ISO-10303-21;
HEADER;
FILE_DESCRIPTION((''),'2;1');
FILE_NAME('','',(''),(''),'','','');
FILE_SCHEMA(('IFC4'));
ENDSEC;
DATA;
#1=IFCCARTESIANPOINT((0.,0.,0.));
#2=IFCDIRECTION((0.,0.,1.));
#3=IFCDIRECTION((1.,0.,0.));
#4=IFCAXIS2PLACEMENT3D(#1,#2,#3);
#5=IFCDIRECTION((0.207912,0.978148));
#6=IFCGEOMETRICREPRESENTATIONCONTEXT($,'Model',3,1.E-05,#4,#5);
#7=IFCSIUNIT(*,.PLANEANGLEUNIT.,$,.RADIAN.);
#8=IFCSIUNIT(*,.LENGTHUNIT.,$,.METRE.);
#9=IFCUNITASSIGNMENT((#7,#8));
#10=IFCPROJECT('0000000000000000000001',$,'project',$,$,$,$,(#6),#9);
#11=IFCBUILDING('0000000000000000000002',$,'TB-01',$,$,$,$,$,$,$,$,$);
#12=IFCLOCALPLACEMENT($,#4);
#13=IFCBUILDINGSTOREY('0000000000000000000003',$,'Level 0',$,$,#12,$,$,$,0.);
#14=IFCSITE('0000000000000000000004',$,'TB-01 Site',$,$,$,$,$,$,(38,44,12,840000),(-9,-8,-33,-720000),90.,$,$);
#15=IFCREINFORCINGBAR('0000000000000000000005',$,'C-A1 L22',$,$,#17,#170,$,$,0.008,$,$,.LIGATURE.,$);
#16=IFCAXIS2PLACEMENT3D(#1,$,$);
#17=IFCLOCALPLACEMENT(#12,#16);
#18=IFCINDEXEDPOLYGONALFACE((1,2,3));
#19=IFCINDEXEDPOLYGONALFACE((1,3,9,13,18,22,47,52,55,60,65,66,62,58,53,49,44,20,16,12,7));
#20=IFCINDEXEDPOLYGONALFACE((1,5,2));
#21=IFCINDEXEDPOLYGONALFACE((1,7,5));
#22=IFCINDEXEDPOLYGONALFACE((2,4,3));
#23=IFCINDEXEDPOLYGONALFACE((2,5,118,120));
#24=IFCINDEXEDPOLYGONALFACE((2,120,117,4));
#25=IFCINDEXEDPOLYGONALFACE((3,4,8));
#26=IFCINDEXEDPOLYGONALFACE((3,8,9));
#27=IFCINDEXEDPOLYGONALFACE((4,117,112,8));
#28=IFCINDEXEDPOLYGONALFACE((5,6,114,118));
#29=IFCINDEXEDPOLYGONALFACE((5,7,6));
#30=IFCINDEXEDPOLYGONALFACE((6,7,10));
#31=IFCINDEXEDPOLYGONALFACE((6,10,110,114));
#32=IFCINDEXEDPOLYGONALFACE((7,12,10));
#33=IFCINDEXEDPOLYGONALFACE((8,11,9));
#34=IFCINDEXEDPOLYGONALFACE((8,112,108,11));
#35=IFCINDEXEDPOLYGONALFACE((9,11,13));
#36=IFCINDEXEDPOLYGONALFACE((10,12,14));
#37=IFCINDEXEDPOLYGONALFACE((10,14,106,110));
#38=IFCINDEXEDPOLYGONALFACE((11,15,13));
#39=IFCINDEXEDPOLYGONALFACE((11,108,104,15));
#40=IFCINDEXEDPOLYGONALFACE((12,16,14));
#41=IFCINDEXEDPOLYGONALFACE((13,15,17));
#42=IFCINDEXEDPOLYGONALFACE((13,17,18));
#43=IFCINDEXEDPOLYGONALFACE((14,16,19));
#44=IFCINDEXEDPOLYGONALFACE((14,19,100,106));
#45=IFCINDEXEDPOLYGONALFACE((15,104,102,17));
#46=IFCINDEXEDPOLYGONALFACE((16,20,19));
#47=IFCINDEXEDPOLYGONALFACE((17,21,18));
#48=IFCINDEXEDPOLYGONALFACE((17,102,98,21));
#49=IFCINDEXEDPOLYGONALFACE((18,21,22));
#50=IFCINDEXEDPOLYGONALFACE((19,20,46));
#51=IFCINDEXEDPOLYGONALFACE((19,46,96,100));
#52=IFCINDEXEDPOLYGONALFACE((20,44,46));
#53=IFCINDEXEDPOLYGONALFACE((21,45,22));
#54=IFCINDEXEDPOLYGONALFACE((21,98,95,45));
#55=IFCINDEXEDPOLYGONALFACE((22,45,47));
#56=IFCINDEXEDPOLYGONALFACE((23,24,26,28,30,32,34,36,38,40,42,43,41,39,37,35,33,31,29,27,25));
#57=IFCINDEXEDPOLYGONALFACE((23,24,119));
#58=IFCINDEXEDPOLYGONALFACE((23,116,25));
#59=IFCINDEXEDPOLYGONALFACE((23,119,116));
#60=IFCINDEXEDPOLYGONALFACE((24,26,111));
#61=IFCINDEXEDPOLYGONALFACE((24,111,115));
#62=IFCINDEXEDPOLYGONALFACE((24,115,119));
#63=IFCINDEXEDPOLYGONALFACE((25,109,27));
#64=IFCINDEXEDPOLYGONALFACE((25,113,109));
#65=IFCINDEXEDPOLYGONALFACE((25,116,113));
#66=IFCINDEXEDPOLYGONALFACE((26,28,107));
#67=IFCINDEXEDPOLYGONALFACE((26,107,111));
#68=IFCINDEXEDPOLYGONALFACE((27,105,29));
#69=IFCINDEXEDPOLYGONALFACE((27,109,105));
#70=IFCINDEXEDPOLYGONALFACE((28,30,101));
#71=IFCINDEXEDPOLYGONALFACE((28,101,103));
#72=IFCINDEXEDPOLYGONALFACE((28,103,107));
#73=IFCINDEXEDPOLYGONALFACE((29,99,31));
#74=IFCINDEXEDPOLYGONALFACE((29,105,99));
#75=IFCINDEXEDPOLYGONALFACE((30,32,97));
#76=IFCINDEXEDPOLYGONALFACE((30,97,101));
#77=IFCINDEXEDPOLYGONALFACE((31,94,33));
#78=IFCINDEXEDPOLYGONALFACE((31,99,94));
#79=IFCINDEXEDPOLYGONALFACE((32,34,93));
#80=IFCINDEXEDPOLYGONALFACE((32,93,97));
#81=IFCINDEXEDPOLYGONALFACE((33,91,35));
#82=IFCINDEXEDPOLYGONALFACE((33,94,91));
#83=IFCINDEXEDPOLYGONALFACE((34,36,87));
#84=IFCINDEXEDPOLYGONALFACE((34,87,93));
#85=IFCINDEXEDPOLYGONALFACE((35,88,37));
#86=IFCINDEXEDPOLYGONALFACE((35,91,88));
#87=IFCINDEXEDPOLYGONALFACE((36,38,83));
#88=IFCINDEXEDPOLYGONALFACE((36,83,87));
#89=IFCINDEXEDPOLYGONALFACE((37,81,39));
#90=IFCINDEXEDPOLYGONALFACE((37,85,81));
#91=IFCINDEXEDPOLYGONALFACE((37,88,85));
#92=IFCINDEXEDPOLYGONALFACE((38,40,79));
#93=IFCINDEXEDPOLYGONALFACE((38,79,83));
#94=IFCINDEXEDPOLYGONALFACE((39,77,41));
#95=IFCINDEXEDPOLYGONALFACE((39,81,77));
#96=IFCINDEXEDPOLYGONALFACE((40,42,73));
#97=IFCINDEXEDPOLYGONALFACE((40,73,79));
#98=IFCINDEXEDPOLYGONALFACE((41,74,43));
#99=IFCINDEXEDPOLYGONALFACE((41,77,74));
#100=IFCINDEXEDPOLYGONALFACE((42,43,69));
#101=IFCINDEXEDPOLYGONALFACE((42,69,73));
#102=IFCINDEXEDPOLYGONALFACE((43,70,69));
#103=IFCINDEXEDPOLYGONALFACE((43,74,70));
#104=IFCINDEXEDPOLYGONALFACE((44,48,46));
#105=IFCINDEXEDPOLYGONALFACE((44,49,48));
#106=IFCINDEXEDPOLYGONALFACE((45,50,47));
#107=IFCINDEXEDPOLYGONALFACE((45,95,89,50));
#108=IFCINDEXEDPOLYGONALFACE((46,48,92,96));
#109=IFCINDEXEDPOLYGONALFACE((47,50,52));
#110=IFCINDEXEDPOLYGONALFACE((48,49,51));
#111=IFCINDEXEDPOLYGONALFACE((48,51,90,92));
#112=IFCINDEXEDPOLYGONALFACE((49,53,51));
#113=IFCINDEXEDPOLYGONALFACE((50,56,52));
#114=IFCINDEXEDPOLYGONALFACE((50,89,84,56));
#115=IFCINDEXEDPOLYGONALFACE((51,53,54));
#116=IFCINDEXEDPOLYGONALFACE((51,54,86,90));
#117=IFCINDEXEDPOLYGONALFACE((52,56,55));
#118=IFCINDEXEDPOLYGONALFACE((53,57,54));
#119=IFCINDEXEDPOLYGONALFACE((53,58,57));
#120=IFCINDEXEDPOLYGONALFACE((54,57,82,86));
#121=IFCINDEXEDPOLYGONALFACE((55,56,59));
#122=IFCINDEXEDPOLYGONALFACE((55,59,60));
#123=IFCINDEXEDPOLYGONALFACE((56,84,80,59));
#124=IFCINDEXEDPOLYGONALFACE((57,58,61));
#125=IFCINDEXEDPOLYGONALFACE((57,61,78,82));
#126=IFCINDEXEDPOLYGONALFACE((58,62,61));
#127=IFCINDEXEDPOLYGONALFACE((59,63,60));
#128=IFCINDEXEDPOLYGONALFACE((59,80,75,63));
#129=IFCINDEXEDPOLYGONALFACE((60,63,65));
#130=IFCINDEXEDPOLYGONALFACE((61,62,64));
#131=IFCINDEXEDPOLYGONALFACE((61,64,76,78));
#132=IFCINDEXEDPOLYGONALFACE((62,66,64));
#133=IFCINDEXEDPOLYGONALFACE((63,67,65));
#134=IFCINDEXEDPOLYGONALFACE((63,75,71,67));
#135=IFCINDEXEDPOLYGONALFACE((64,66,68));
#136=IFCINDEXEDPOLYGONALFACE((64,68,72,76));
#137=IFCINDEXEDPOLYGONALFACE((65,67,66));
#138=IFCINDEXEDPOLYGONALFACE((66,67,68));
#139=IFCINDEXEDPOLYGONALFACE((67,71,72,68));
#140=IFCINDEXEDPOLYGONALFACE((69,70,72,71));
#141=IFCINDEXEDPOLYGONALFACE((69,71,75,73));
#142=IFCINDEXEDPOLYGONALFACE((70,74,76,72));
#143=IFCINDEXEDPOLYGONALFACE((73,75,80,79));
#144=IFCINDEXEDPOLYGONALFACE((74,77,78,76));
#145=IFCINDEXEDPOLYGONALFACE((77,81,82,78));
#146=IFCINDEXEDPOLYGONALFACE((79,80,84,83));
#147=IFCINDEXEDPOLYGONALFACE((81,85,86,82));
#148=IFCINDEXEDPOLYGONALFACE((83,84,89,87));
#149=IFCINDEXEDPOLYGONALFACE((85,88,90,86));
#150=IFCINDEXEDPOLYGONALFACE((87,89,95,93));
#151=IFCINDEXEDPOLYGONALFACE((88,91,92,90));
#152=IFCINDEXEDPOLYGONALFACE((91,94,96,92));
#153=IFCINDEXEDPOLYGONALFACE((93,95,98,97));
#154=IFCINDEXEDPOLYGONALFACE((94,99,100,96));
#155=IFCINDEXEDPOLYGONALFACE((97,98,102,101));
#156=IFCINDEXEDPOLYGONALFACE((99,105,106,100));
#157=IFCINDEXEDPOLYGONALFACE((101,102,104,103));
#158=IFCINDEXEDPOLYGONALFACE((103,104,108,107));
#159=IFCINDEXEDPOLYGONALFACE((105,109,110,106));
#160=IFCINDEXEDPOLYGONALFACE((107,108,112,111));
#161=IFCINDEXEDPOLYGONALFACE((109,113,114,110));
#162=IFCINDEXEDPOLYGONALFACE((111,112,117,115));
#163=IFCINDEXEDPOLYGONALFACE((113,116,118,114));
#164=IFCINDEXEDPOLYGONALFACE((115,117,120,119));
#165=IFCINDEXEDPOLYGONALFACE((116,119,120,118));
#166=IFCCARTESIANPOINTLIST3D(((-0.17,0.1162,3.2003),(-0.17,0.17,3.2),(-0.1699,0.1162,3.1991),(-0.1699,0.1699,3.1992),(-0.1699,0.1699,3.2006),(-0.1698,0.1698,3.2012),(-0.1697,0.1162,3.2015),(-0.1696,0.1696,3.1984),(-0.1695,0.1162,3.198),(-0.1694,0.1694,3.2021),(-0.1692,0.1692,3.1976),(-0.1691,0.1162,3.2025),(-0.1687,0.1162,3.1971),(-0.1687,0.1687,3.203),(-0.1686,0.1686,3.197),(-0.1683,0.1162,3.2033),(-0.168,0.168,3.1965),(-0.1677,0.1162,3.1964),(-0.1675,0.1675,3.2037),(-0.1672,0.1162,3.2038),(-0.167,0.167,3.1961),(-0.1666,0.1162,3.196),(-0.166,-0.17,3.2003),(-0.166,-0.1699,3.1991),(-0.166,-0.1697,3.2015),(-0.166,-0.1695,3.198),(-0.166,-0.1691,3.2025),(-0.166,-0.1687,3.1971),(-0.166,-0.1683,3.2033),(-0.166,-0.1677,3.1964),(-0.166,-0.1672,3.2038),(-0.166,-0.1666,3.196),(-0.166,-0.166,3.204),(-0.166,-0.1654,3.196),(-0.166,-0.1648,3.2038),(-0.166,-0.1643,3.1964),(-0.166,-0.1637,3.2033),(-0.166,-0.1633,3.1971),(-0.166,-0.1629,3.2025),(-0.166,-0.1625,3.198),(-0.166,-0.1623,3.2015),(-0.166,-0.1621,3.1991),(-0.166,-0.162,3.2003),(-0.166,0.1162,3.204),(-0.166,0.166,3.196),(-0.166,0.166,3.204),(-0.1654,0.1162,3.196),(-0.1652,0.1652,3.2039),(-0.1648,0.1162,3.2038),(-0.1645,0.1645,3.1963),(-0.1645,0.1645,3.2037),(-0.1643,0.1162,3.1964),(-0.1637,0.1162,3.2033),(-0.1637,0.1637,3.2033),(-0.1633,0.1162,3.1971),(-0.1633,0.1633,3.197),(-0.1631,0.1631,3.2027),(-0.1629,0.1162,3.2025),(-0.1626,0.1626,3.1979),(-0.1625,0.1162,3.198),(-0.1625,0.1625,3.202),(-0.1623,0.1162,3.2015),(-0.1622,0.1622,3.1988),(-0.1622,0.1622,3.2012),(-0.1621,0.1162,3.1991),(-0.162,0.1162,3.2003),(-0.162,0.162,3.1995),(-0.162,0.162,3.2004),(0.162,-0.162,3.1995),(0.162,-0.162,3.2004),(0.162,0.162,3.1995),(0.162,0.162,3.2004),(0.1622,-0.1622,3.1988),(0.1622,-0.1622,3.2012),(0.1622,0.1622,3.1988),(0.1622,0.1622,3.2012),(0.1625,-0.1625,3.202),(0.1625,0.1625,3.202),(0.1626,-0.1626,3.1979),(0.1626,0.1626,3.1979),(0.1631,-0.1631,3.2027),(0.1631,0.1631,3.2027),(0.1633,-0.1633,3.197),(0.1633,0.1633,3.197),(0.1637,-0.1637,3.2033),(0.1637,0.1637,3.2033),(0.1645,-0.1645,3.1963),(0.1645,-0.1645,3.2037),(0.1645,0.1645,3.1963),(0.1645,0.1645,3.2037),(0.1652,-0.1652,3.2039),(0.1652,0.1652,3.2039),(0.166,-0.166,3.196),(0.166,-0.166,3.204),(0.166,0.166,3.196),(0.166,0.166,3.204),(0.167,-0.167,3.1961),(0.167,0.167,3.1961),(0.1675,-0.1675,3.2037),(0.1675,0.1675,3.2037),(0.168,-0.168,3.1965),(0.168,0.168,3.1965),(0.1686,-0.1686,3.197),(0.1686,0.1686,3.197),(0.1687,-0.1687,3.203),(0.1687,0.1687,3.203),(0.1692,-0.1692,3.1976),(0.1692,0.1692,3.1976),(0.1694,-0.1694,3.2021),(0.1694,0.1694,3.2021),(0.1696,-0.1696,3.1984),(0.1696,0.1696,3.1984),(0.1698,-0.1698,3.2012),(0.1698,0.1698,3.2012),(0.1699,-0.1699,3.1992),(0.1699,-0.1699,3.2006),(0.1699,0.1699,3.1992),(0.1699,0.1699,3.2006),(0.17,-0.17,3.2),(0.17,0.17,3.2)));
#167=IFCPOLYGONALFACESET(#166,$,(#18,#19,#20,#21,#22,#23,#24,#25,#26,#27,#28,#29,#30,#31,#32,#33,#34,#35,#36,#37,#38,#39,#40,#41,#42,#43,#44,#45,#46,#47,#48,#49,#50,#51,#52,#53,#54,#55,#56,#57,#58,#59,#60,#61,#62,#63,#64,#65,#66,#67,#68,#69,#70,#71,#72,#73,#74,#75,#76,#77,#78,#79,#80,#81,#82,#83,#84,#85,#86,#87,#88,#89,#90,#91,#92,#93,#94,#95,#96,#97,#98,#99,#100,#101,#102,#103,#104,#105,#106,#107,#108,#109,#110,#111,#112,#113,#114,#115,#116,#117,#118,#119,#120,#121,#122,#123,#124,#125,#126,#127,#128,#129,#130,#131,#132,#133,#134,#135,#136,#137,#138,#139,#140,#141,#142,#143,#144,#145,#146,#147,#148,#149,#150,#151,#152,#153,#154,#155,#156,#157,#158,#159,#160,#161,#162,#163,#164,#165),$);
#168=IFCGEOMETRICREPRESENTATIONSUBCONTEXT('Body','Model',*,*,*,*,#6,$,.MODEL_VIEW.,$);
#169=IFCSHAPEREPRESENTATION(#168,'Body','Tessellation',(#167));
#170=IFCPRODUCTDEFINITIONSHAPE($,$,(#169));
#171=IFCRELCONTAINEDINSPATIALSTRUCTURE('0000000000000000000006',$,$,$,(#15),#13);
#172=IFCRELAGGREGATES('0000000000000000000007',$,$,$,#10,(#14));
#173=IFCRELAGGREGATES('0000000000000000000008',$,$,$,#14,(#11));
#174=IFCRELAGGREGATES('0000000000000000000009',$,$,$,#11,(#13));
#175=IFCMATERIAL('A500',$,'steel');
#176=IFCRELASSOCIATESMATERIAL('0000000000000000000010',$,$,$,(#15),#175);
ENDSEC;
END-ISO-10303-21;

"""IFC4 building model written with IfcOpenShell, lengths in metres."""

from ifc_helpers import new_model, entity, si_unit, direction, origin_with_axes, place, context, subcontext, project, spatial, material, element, save


model = new_model("IFC4")

# Units and contexts
model_context = context("Model", 3, precision=1e-05, world=origin_with_axes(), true_north=direction((0.207912, 0.978148)))
body_context = subcontext(model_context, "Body", "Model", "MODEL_VIEW")
ifc_project = project(units=[si_unit("PLANEANGLEUNIT", "RADIAN"), si_unit("LENGTHUNIT", "METRE")], contexts=[model_context])

# Site, building, storey
site = spatial("IfcSite", under=ifc_project, Name="TB-01 Site", RefLatitude=(38, 44, 12, 840000), RefLongitude=(-9, -8, -33, -720000), RefElevation=90.0)
building = spatial("IfcBuilding", under=site, Name="TB-01")
storey_placement = place(None, origin_with_axes())
storey = spatial("IfcBuildingStorey", under=building, at=storey_placement, Name="Level 0", Elevation=0.0)

# Reinforcing bar
ifc_material_1 = material(Name="A500", Category="steel")
reinforcing_bar_1_placement = place(storey_placement, origin_with_axes())
element("IfcReinforcingBar", 1, at=reinforcing_bar_1_placement, inside=storey, material=ifc_material_1, Name="C-A1 L22", NominalDiameter=0.008, PredefinedType="LIGATURE", context=body_context, shape_type="AdvancedSweptSolid", body=[
    entity("IfcSweptDiskSolid", entity("IfcPolyline", [entity("IfcCartesianPoint", [-0.166, -0.166, 3.2]), entity("IfcCartesianPoint", [0.166, -0.166, 3.2]), entity("IfcCartesianPoint", [0.166, 0.166, 3.2]), entity("IfcCartesianPoint", [-0.166, 0.166, 3.2]), entity("IfcCartesianPoint", [-0.166, 0.1162, 3.2])]), 0.004),
])

save(model, "model.ifc")
